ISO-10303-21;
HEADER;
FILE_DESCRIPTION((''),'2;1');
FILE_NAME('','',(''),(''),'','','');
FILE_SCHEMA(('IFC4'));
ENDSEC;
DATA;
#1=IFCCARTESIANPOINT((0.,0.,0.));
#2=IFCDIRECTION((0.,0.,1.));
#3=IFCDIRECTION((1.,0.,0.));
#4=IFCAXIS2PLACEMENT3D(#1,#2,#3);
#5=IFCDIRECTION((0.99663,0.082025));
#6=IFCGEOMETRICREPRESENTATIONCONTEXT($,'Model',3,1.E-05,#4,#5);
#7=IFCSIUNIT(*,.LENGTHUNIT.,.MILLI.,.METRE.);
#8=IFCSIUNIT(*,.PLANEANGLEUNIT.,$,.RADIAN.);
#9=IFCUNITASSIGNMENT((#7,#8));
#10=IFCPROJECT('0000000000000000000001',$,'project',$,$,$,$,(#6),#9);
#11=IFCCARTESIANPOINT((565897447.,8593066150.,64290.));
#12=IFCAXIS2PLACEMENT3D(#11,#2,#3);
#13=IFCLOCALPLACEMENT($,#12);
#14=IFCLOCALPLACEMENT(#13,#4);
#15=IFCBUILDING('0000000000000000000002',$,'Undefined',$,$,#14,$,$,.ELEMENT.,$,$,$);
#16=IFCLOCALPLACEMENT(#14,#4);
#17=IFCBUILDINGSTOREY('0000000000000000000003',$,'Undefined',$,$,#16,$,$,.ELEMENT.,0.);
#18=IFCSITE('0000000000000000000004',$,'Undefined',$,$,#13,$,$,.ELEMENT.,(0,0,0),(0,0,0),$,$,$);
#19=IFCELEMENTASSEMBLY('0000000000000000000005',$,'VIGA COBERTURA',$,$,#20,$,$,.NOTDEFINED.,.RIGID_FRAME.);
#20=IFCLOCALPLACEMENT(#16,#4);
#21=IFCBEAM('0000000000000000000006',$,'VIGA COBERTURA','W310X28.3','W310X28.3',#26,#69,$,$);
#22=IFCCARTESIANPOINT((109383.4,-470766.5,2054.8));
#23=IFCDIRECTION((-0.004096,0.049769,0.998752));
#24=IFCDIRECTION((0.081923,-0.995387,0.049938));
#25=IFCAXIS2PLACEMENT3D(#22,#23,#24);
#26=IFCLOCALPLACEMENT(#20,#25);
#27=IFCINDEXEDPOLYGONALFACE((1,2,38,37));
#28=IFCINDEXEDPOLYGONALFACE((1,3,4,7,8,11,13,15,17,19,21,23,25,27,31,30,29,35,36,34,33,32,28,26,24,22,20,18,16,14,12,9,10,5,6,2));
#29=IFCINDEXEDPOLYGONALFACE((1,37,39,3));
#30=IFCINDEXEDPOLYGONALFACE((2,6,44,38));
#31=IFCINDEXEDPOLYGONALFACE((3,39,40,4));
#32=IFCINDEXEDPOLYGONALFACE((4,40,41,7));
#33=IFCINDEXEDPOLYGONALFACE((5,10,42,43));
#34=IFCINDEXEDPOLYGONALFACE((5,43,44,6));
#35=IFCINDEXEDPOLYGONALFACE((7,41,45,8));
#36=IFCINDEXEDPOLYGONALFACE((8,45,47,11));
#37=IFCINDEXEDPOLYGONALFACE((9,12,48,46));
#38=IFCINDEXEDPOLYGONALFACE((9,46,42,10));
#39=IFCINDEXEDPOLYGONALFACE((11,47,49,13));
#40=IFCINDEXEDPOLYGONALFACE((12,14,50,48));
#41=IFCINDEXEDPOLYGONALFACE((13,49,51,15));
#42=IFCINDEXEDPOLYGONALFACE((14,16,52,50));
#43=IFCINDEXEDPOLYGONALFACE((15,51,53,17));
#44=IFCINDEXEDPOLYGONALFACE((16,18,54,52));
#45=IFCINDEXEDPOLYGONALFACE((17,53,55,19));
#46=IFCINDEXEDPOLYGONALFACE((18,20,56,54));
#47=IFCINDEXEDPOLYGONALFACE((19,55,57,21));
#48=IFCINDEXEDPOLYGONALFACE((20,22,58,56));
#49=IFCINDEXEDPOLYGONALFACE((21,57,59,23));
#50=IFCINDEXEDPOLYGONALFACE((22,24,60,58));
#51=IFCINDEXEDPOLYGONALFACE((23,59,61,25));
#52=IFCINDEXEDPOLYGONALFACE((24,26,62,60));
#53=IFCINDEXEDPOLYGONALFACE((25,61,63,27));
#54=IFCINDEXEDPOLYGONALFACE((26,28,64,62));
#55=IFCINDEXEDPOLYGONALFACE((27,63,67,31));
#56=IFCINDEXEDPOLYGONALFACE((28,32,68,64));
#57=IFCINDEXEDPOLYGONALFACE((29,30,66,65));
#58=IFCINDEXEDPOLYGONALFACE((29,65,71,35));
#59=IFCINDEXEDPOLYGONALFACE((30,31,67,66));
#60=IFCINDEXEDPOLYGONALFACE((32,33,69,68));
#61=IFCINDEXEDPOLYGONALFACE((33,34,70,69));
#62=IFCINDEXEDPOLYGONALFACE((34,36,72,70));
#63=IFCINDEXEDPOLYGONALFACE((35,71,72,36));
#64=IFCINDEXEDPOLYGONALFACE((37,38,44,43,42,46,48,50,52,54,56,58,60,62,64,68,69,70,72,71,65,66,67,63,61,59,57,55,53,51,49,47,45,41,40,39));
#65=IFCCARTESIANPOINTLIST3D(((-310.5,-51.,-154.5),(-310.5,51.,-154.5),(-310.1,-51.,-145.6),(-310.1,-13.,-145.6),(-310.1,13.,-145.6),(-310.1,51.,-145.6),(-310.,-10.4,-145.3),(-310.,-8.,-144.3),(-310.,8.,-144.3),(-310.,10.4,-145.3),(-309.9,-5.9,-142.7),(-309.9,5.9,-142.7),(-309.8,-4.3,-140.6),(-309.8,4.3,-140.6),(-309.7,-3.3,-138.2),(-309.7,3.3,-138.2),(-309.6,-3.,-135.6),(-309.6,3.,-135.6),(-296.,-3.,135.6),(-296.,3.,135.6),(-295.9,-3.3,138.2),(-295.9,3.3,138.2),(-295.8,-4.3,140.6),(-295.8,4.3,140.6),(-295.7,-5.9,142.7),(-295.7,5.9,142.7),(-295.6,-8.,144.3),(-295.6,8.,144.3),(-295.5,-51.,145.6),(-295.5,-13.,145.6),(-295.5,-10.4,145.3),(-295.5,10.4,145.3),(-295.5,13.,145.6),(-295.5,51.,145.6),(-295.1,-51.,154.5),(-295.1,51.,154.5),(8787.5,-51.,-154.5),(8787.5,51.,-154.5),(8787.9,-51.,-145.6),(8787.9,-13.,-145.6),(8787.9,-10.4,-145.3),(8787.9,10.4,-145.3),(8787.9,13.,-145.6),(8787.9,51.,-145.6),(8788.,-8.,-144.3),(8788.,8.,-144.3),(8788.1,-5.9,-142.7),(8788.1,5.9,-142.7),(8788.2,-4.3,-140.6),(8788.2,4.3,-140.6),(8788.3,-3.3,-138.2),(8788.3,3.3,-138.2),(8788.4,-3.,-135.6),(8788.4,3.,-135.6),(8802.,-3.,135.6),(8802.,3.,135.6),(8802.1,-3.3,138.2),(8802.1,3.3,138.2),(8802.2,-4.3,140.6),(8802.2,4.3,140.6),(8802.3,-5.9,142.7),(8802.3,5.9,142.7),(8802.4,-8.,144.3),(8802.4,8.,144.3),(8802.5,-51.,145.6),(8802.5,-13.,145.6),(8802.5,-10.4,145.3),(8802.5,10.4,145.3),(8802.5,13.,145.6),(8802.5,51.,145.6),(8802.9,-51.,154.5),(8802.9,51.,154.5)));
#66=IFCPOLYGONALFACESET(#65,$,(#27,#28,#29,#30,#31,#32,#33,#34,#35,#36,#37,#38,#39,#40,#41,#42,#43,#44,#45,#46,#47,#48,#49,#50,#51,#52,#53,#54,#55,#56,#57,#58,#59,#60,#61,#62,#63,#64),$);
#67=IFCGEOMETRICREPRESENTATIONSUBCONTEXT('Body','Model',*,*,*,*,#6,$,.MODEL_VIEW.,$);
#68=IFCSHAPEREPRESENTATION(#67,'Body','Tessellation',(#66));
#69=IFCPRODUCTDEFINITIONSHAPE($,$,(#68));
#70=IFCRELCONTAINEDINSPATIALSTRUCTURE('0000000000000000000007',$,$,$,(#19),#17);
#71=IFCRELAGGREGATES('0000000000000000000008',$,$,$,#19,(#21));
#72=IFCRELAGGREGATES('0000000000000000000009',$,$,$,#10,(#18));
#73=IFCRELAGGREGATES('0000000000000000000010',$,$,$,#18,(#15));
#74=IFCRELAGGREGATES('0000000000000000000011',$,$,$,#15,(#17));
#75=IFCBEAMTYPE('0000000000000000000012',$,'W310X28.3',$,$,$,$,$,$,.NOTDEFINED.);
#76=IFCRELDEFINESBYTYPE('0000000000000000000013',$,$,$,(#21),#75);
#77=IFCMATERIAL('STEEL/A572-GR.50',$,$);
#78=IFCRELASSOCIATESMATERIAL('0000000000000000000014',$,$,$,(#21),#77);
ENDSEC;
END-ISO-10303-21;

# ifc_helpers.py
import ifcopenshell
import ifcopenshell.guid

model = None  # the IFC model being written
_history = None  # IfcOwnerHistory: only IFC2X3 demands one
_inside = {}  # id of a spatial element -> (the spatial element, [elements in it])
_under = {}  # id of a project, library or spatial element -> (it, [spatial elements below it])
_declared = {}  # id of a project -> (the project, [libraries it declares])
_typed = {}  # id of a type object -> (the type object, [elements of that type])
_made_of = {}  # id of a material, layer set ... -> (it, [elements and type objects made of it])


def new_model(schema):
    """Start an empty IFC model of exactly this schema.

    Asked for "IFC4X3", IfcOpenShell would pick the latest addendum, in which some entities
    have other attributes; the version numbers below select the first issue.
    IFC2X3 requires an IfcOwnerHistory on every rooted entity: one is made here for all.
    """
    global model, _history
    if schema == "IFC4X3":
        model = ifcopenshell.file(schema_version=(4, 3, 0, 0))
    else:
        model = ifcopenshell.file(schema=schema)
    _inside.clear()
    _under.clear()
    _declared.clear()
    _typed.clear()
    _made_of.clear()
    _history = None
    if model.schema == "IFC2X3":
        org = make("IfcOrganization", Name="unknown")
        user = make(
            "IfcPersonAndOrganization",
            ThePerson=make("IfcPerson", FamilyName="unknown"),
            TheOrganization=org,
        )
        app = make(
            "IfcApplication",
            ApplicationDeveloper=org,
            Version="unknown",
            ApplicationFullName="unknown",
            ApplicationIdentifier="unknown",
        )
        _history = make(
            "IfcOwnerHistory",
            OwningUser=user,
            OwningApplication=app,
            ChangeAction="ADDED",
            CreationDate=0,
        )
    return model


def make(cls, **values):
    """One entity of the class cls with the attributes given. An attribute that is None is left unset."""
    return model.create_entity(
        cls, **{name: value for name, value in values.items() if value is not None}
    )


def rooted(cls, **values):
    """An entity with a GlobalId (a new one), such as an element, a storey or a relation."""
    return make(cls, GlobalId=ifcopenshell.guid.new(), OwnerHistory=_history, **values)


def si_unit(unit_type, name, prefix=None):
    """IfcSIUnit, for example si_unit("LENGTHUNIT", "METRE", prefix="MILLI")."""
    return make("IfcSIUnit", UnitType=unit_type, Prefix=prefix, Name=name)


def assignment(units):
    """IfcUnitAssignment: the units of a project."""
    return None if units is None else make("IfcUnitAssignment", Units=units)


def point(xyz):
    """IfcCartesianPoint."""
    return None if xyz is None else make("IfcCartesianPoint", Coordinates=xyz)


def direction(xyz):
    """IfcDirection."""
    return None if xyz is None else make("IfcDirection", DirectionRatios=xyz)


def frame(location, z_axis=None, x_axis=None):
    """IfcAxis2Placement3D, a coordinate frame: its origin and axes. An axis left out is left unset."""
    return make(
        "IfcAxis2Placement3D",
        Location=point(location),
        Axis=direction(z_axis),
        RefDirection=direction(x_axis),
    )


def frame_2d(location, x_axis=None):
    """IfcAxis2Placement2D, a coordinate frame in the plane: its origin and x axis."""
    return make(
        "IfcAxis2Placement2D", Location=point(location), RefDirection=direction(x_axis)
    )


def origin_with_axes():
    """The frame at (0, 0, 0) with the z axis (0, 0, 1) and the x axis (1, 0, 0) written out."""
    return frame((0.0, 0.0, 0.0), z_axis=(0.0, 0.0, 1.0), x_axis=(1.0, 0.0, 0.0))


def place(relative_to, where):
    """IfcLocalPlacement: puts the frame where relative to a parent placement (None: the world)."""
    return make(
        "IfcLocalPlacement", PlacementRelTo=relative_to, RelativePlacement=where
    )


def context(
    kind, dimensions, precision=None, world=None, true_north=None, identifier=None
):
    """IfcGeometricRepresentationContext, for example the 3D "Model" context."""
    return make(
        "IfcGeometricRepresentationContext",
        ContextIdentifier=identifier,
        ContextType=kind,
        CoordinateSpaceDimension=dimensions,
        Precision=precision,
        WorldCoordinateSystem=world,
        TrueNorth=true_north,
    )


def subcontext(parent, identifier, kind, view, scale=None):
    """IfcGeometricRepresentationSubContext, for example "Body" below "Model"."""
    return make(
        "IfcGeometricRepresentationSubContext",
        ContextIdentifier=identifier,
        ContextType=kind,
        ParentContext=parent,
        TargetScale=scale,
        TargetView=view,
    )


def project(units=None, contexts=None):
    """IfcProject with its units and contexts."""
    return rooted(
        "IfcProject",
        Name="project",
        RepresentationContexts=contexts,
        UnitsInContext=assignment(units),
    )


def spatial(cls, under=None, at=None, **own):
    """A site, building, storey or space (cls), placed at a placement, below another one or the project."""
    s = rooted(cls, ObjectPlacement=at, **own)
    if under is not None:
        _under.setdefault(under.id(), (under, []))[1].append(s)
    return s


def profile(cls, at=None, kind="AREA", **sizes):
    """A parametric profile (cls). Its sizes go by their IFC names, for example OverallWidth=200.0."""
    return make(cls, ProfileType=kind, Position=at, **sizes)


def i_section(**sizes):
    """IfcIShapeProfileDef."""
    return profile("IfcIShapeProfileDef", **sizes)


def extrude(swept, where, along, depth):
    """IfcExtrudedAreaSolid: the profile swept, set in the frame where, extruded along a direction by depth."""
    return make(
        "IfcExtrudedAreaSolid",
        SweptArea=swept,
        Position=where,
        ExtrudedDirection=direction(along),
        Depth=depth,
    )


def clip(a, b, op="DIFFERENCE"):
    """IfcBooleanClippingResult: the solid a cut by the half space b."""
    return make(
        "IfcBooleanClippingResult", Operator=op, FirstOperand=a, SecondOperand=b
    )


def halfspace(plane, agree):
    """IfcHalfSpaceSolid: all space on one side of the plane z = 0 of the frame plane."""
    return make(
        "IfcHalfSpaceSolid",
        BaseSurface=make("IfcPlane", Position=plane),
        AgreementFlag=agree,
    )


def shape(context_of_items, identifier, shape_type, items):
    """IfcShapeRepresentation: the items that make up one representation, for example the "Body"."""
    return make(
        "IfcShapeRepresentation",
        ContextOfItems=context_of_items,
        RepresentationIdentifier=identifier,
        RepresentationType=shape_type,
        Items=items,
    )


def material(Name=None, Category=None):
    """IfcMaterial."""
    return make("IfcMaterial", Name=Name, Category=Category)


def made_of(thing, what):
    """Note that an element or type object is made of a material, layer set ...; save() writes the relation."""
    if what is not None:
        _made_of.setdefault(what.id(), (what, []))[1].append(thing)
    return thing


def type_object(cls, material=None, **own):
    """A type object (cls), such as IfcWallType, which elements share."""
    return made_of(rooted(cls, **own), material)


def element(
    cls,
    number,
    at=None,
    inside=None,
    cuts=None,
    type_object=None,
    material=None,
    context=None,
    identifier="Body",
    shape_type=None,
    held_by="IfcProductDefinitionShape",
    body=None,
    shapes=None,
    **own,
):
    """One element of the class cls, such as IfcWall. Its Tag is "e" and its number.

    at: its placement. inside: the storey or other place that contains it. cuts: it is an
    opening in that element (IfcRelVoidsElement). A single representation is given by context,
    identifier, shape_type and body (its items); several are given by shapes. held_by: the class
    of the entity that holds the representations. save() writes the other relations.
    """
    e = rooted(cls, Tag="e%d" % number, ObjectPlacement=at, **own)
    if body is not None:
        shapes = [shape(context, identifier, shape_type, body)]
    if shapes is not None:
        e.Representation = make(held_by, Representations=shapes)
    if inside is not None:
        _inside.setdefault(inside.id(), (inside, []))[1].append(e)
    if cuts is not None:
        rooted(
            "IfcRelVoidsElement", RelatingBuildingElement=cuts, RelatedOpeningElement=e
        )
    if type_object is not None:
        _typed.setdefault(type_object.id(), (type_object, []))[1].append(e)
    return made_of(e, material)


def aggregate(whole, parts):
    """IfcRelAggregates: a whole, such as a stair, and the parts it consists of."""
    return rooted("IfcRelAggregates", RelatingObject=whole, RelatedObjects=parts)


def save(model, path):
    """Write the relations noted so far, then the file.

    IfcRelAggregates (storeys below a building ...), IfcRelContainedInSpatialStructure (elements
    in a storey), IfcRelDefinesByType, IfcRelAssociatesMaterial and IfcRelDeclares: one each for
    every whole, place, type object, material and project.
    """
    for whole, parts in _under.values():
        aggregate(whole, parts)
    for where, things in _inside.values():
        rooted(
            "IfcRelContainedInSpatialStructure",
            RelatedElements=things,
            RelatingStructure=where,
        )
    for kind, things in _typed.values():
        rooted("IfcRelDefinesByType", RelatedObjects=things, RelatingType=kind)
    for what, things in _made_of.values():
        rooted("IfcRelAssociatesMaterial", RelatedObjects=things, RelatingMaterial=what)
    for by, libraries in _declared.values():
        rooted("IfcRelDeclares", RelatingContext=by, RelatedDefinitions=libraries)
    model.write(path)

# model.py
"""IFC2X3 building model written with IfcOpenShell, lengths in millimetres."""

from ifc_helpers import new_model, si_unit, direction, frame, frame_2d, origin_with_axes, place, context, subcontext, project, spatial, i_section, extrude, clip, halfspace, material, type_object, element, aggregate, save


model = new_model("IFC2X3")

# Units and contexts
model_context = context("Model", 3, precision=1e-05, world=origin_with_axes(), true_north=direction((0.99663, 0.082025)))
body_context = subcontext(model_context, "Body", "Model", "MODEL_VIEW")
ifc_project = project(units=[si_unit("LENGTHUNIT", "METRE", prefix="MILLI"), si_unit("PLANEANGLEUNIT", "RADIAN")], contexts=[model_context])

# Site, building, storey
site_placement = place(None, frame((565897447.0, 8593066150.0, 64290.0), z_axis=(0.0, 0.0, 1.0), x_axis=(1.0, 0.0, 0.0)))
site = spatial("IfcSite", under=ifc_project, at=site_placement, Name="Undefined", CompositionType="ELEMENT", RefLatitude=(0, 0, 0), RefLongitude=(0, 0, 0))
building_placement = place(site_placement, origin_with_axes())
building = spatial("IfcBuilding", under=site, at=building_placement, Name="Undefined", CompositionType="ELEMENT")
storey_placement = place(building_placement, origin_with_axes())
storey = spatial("IfcBuildingStorey", under=building, at=storey_placement, Name="Undefined", CompositionType="ELEMENT", Elevation=0.0)

# Element assembly, beam
assembly_1_placement = place(storey_placement, origin_with_axes())
assembly_1 = element("IfcElementAssembly", 1, at=assembly_1_placement, inside=storey, Name="VIGA COBERTURA", AssemblyPlace="NOTDEFINED", PredefinedType="RIGID_FRAME")
ifc_material_1 = material(Name="STEEL/A572-GR.50")
beam_type_1 = type_object("IfcBeamType", Name="W310X28.3", PredefinedType="NOTDEFINED")
beam_1_placement = place(assembly_1_placement, frame((109383.4, -470766.5, 2054.8), z_axis=(-0.004096, 0.049769, 0.998752), x_axis=(0.081923, -0.995387, 0.049938)))
beam_1 = element("IfcBeam", 2, at=beam_1_placement, type_object=beam_type_1, material=ifc_material_1, Name="VIGA COBERTURA", Description="W310X28.3", ObjectType="W310X28.3", context=body_context, shape_type="Clipping", body=[
    clip(clip(extrude(i_section(OverallWidth=102.0, OverallDepth=309.0, WebThickness=6.0, FlangeThickness=8.9, FilletRadius=10.0, at=frame_2d((0.0, 0.0), x_axis=(1.0, 0.0))), frame((8827.6, 0.0, 0.0), z_axis=(-1.0, 0.0, 0.0), x_axis=(0.0, -1.0, 0.0)), (0.0, 0.0, 1.0), 9162.8), halfspace(frame((8787.5, 0.0, -154.5), z_axis=(-0.998752, 0.0, 0.049938), x_axis=(0.0, 1.0, 0.0)), True)), halfspace(frame((-295.1, 0.0, 154.5), z_axis=(0.998752, 0.0, -0.049938), x_axis=(0.0, 1.0, 0.0)), True)),
])
aggregate(assembly_1, [beam_1])

save(model, "model.ifc")
